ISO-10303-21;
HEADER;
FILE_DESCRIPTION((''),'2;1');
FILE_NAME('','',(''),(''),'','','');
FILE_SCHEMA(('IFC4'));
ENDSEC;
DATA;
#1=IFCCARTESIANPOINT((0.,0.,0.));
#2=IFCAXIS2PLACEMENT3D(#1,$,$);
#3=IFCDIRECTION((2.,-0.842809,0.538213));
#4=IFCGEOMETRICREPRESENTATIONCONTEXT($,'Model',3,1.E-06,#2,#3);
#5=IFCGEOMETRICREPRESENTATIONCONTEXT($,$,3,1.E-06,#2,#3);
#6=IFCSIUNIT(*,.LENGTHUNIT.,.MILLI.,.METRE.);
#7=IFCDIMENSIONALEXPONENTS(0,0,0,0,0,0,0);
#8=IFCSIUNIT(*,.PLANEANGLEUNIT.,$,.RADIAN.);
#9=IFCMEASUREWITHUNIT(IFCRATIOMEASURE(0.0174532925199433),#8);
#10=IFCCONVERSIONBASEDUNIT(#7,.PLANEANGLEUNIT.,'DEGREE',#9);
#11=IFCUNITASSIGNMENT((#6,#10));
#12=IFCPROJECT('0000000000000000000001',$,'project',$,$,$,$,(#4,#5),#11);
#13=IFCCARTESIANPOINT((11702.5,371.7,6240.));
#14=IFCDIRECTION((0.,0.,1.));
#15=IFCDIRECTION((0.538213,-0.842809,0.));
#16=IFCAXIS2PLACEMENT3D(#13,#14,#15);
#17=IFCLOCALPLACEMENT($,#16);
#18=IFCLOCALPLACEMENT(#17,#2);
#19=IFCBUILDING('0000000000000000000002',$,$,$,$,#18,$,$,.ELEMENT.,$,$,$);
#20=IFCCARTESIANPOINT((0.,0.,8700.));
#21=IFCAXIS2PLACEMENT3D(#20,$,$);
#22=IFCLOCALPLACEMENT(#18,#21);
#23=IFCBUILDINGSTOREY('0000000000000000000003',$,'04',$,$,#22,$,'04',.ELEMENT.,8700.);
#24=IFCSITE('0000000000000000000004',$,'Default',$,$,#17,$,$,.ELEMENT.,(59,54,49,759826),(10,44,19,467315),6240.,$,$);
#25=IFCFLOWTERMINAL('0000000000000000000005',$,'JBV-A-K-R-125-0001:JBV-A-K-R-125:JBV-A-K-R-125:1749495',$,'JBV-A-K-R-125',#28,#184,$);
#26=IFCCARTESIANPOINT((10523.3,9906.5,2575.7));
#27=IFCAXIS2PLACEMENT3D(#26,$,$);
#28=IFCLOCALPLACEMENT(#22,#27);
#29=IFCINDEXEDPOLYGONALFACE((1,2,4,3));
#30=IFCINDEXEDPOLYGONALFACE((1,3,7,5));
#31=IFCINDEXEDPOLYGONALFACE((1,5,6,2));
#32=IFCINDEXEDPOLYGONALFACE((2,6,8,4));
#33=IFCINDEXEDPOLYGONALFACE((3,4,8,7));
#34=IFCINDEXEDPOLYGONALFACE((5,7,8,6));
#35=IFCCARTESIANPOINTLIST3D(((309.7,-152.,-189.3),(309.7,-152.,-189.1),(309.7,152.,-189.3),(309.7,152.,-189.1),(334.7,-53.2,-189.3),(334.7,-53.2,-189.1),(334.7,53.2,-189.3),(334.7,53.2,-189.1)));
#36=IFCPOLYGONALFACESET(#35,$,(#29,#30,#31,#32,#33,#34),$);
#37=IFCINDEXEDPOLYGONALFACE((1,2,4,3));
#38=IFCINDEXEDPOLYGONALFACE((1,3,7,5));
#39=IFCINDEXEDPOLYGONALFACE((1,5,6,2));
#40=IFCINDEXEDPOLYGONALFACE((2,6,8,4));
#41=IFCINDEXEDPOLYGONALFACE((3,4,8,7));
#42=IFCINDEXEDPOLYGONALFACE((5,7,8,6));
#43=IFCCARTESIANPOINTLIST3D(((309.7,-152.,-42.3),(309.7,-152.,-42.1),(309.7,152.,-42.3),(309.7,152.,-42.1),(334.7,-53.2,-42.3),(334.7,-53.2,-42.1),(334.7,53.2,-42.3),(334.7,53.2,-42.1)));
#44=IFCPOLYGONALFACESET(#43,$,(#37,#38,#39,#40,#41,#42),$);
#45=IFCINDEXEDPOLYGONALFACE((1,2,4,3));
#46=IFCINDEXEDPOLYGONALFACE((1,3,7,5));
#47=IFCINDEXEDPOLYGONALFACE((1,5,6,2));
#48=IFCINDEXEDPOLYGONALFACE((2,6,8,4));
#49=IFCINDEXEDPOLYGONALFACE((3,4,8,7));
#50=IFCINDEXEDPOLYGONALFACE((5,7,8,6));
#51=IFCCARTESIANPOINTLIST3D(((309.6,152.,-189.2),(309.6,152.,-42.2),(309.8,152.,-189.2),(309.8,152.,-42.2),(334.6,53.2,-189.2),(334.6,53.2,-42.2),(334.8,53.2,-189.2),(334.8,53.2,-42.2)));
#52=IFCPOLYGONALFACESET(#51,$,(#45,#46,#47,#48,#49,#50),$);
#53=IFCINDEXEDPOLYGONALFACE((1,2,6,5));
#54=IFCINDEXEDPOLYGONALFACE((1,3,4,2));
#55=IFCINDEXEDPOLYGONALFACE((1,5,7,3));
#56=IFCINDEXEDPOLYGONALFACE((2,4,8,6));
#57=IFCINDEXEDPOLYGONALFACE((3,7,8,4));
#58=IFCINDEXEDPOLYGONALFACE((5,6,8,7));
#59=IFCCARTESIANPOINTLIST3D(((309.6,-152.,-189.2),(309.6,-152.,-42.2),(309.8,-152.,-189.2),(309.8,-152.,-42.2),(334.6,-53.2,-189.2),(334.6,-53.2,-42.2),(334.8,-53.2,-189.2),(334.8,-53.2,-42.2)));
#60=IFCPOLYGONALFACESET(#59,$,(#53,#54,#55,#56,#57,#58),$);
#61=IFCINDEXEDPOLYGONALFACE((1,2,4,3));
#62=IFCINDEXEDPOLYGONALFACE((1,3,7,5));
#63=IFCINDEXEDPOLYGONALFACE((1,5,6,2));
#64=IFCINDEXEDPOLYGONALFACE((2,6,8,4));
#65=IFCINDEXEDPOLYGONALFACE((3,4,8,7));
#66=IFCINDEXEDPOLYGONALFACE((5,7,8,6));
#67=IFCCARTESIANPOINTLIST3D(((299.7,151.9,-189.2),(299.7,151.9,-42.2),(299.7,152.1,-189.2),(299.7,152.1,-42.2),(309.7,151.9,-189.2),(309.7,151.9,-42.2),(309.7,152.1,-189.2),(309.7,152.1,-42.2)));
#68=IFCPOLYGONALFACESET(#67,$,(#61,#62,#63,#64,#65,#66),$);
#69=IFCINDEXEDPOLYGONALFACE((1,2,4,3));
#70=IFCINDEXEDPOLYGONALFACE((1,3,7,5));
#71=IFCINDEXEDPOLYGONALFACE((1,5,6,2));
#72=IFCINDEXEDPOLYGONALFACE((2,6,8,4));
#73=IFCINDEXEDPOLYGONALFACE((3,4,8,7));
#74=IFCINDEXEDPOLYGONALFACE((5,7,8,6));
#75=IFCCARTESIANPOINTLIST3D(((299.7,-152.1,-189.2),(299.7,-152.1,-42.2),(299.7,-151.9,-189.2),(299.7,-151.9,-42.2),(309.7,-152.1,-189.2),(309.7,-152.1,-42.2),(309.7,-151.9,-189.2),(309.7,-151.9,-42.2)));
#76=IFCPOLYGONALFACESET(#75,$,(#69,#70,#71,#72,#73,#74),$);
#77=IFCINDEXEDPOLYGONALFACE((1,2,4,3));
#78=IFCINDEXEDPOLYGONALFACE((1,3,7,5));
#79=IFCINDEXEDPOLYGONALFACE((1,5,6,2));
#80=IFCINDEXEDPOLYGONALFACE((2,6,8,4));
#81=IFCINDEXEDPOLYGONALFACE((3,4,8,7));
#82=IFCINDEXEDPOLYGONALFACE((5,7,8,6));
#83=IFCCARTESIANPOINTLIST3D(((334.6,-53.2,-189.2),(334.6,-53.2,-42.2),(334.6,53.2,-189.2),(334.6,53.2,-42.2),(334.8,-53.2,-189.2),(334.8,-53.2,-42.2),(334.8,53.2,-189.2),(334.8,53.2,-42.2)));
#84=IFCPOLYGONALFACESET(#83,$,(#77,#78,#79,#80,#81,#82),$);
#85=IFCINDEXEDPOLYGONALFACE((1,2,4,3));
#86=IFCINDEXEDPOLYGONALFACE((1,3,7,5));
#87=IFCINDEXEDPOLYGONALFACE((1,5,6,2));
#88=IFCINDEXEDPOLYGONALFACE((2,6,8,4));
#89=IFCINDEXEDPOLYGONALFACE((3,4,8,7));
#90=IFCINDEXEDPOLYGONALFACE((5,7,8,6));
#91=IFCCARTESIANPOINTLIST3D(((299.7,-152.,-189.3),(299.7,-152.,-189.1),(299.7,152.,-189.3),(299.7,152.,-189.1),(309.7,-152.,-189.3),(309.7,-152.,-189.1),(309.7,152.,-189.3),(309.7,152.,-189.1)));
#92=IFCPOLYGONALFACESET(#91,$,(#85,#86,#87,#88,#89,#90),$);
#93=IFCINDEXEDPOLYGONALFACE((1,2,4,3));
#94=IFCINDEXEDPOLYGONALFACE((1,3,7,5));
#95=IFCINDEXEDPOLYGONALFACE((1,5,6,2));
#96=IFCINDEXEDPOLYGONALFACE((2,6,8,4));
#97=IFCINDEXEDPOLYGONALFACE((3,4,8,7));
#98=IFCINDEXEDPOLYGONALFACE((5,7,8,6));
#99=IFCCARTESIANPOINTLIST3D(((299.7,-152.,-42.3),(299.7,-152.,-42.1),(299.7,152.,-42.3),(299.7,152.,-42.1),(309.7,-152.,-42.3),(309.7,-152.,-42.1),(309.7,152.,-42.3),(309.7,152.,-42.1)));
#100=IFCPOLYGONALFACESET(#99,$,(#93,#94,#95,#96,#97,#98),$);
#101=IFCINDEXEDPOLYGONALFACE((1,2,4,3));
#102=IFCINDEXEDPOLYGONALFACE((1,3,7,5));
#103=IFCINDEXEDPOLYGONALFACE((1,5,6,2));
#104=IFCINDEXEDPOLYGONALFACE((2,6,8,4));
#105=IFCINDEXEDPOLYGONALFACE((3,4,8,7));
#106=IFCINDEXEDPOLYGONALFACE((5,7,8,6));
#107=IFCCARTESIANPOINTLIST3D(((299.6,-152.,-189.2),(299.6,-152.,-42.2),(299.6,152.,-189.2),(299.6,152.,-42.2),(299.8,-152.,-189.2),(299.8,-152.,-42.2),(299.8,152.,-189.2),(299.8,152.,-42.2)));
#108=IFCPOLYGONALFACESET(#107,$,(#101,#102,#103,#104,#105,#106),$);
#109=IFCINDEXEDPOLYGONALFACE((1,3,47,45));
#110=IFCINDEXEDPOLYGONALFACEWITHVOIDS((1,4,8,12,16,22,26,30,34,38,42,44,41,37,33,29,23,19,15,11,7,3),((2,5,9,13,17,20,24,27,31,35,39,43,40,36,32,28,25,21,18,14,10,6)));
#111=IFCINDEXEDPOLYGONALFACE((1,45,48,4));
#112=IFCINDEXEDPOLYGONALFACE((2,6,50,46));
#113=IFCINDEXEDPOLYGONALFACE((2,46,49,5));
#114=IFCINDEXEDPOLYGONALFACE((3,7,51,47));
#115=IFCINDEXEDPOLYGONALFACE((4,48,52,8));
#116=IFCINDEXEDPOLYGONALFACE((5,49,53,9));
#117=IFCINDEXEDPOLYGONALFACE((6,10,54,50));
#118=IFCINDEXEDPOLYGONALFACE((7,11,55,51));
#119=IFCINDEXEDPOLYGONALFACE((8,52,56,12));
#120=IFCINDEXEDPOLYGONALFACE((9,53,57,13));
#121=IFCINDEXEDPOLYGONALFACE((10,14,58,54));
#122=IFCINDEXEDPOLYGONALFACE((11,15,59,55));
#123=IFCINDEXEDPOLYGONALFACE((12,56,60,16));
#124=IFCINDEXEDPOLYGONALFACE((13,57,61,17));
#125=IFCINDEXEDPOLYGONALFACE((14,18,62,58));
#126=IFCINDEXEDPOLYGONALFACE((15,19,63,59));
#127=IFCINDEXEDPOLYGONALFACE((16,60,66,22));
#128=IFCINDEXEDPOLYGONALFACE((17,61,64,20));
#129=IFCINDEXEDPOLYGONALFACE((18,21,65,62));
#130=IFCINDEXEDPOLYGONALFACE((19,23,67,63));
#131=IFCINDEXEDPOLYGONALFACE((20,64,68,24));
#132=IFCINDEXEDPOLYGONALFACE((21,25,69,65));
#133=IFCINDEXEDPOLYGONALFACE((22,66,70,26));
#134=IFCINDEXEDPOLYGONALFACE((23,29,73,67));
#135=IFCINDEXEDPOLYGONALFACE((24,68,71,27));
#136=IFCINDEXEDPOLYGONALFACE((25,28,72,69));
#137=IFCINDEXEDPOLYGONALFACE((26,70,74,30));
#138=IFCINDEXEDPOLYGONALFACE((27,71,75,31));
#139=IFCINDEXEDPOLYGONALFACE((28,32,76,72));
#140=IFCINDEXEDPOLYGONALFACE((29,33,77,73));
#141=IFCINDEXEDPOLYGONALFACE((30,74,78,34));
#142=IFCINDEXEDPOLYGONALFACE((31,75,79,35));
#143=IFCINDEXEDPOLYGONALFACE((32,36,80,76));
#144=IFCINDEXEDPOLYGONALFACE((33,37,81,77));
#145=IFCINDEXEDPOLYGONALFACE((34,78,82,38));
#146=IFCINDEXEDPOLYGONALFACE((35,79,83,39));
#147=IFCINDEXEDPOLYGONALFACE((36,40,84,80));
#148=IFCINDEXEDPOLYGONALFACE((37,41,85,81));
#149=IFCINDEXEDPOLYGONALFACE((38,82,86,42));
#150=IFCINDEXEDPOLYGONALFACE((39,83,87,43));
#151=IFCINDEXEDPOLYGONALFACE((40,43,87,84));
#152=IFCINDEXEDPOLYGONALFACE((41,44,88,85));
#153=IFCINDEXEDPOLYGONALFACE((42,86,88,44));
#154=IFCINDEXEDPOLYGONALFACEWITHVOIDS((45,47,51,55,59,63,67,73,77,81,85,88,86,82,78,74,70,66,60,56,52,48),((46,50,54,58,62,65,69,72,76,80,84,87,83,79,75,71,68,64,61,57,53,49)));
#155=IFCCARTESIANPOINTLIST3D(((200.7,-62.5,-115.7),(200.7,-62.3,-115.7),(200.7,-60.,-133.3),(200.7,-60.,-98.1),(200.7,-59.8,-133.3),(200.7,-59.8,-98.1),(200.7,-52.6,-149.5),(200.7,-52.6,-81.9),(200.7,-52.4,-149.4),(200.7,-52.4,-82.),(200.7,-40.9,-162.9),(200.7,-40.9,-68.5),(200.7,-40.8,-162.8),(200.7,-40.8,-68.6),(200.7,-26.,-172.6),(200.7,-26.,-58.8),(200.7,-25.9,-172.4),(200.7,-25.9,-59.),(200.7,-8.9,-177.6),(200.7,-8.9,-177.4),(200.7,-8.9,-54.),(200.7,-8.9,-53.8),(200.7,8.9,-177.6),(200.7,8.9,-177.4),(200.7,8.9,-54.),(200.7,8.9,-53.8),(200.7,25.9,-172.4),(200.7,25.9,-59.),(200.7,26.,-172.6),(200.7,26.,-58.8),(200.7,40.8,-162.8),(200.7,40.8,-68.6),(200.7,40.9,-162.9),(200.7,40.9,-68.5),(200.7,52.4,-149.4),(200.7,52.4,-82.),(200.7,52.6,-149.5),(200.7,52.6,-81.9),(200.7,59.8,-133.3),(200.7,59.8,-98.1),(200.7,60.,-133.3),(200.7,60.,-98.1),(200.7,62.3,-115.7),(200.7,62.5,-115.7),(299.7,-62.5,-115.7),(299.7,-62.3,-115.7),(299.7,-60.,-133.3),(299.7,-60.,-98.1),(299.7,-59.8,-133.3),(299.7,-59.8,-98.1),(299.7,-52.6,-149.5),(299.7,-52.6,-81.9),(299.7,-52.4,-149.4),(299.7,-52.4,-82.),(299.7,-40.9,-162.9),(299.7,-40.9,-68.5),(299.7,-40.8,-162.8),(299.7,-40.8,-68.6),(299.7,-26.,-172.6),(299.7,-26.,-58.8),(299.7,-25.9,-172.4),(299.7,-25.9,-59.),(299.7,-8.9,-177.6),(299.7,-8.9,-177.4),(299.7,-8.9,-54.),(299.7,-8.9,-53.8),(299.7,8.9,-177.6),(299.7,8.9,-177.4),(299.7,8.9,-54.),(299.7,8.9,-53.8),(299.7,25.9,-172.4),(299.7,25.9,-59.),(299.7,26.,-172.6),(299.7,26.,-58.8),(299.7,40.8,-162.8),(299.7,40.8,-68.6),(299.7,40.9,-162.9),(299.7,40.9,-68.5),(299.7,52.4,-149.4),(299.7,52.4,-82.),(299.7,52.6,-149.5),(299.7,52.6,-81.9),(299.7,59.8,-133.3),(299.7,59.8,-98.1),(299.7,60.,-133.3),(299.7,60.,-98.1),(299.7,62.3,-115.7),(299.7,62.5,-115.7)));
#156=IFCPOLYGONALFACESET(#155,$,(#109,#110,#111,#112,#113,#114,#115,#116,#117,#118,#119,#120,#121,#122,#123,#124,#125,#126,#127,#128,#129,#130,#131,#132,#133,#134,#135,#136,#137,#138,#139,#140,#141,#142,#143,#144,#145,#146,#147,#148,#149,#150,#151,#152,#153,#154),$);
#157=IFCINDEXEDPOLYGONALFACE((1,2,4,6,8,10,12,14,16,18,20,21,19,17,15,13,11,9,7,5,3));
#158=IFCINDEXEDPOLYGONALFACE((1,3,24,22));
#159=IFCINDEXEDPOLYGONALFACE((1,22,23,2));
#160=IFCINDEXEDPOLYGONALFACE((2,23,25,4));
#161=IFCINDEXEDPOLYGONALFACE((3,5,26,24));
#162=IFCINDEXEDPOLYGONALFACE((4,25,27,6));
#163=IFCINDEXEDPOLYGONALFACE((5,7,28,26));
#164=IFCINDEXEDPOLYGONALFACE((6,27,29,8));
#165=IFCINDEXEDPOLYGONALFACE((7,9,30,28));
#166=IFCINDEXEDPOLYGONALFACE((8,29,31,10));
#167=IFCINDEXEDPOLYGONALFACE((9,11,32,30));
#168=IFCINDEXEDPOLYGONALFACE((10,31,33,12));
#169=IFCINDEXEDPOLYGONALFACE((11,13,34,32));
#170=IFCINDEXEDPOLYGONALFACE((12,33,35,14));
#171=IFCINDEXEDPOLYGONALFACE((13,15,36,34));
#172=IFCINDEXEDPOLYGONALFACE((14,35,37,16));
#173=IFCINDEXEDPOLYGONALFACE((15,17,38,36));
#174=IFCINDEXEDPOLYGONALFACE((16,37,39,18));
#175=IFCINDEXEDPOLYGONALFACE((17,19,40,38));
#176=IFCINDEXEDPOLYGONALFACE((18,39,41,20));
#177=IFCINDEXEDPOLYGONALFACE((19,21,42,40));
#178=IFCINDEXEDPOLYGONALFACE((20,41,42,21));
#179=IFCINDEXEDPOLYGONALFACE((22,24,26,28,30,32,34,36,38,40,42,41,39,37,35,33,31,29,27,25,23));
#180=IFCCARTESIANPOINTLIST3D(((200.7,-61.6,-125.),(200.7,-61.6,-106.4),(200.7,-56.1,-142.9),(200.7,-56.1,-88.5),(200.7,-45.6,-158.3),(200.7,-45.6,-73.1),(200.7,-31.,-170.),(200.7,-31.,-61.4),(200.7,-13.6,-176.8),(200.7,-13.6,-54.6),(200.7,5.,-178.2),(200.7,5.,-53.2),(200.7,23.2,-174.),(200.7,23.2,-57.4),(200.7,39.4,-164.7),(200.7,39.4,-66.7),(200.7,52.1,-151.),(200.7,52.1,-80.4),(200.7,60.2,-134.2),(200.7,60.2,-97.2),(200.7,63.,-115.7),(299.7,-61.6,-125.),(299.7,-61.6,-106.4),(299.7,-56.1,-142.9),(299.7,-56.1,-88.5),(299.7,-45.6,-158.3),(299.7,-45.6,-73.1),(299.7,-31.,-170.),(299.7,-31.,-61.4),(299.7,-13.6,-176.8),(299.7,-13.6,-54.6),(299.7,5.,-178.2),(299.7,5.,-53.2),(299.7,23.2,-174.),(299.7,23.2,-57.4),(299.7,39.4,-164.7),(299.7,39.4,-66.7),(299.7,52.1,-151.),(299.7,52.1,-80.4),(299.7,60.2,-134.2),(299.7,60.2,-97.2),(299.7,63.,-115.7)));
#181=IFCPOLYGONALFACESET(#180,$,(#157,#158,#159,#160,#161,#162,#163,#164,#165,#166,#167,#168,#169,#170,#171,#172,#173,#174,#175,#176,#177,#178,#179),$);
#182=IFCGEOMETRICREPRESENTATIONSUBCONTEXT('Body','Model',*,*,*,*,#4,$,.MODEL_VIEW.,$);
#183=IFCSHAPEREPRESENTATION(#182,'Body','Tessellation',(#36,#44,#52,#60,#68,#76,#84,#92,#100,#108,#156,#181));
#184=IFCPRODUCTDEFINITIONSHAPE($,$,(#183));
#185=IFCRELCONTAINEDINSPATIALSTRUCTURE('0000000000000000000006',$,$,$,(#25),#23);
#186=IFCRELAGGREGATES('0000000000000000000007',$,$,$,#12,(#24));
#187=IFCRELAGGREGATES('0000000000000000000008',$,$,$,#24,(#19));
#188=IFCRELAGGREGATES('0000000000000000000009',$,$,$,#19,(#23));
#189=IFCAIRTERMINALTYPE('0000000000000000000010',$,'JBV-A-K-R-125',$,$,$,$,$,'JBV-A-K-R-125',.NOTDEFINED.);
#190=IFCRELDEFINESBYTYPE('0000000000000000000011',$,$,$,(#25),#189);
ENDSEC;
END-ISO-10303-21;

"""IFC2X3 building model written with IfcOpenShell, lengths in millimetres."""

from ifc_helpers import new_model, entity, si_unit, converted_unit, direction, frame, frame_2d, origin, origin_2d_with_axis, place, context, subcontext, project, spatial, polyline, circle_curve, parameter, trimmed, segment, composite_curve, rectangle, circle, outline, extrude, source, transform, mapped, type_object, type_shapes, element, save


model = new_model("IFC2X3")

# Units and contexts
model_context = context("Model", 3, precision=1e-06, world=origin(), true_north=direction((2.0, -0.842809, 0.538213)))
context_of_model = context(None, 3, precision=1e-06, world=origin(), true_north=direction((2.0, -0.842809, 0.538213)))
body_context = subcontext(model_context, "Body", "Model", "MODEL_VIEW")
ifc_project = project(units=[si_unit("LENGTHUNIT", "METRE", prefix="MILLI"), converted_unit("PLANEANGLEUNIT", "DEGREE", entity("IfcRatioMeasure", 0.0174532925199433), si_unit("PLANEANGLEUNIT", "RADIAN"), dimensions=[0, 0, 0, 0, 0, 0, 0])], contexts=[model_context, context_of_model])

# Site, building, storey
site_placement = place(None, frame((11702.5, 371.7, 6240.0), z_axis=(0.0, 0.0, 1.0), x_axis=(0.538213, -0.842809, 0.0)))
site = spatial("IfcSite", under=ifc_project, at=site_placement, Name="Default", CompositionType="ELEMENT", RefLatitude=(59, 54, 49, 759826), RefLongitude=(10, 44, 19, 467315), RefElevation=6240.0)
building_placement = place(site_placement, origin())
building = spatial("IfcBuilding", under=site, at=building_placement, CompositionType="ELEMENT")
storey_placement = place(building_placement, frame((0.0, 0.0, 8700.0)))
storey = spatial("IfcBuildingStorey", under=building, at=storey_placement, Name="04", LongName="04", CompositionType="ELEMENT", Elevation=8700.0)

# Flow terminal
air_terminal_type_1 = type_object("IfcAirTerminalType", Name="JBV-A-K-R-125", ElementType="JBV-A-K-R-125", PredefinedType="NOTDEFINED")
shared_shape_1 = source(origin(), body_context, "Body", "SweptSolid", [
    extrude(outline(polyline([(-152.0, -12.5), (152.0, -12.5), (53.2, 12.5), (-53.2, 12.5), (-152.0, -12.5)])), frame((322.2, 0.0, -189.3), z_axis=(0.0, 0.0, 1.0), x_axis=(0.0, -1.0, 0.0)), (0.0, 0.0, 1.0), 0.2),
    extrude(outline(polyline([(-152.0, -12.5), (152.0, -12.5), (53.2, 12.5), (-53.2, 12.5), (-152.0, -12.5)])), frame((322.2, 0.0, -42.3), z_axis=(0.0, 0.0, 1.0), x_axis=(0.0, -1.0, 0.0)), (0.0, 0.0, 1.0), 0.2),
    extrude(rectangle(XDim=0.2, YDim=101.9, at=frame_2d((0.0, 0.0), x_axis=(1.0, 0.0))), frame((322.2, 102.6, -189.2), z_axis=(0.0, 0.0, 1.0), x_axis=(0.969446, 0.245305, 0.0)), (0.0, 0.0, 1.0), 147.0),
    extrude(rectangle(XDim=0.2, YDim=101.9, at=frame_2d((0.0, 0.0), x_axis=(1.0, 0.0))), frame((322.2, -102.6, -189.2), z_axis=(0.0, 0.0, 1.0), x_axis=(-0.969446, 0.245305, 0.0)), (0.0, 0.0, 1.0), 147.0),
    extrude(rectangle(XDim=0.2, YDim=10.0, at=frame_2d((0.0, 0.0), x_axis=(1.0, 0.0))), frame((304.7, 152.0, -189.2), z_axis=(0.0, 0.0, 1.0), x_axis=(0.0, 1.0, 0.0)), (0.0, 0.0, 1.0), 147.0),
    extrude(rectangle(XDim=0.2, YDim=10.0, at=frame_2d((0.0, 0.0), x_axis=(1.0, 0.0))), frame((304.7, -152.0, -189.2), z_axis=(0.0, 0.0, 1.0), x_axis=(0.0, 1.0, 0.0)), (0.0, 0.0, 1.0), 147.0),
    extrude(rectangle(XDim=0.2, YDim=106.4, at=frame_2d((0.0, 0.0), x_axis=(1.0, 0.0))), frame((334.7, 0.0, -189.2)), (0.0, 0.0, 1.0), 147.0),
    extrude(rectangle(XDim=304.0, YDim=10.0, at=frame_2d((0.0, 0.0), x_axis=(1.0, 0.0))), frame((304.7, 0.0, -189.3), z_axis=(0.0, 0.0, 1.0), x_axis=(0.0, -1.0, 0.0)), (0.0, 0.0, 1.0), 0.2),
    extrude(rectangle(XDim=304.0, YDim=10.0, at=frame_2d((0.0, 0.0), x_axis=(1.0, 0.0))), frame((304.7, 0.0, -42.3), z_axis=(0.0, 0.0, 1.0), x_axis=(0.0, -1.0, 0.0)), (0.0, 0.0, 1.0), 0.2),
    extrude(rectangle(XDim=0.2, YDim=304.0, at=frame_2d((0.0, 0.0), x_axis=(1.0, 0.0))), frame((299.7, 0.0, -189.2)), (0.0, 0.0, 1.0), 147.0),
    extrude(outline(composite_curve([segment(trimmed(circle_curve(origin_2d_with_axis(), 62.5), [parameter(0.0)], [parameter(180.0)], True, "PARAMETER"), True, "CONTINUOUS"), segment(trimmed(circle_curve(origin_2d_with_axis(), 62.5), [parameter(180.0)], [parameter(360.0)], True, "PARAMETER"), True, "CONTINUOUS")], self_intersect=False), holes=[composite_curve([segment(trimmed(circle_curve(origin_2d_with_axis(), 62.3), [parameter(180.0)], [parameter(360.0)], True, "PARAMETER"), False, "CONTINUOUS"), segment(trimmed(circle_curve(origin_2d_with_axis(), 62.3), [parameter(0.0)], [parameter(180.0)], True, "PARAMETER"), False, "CONTINUOUS")], self_intersect=False)]), frame((200.7, 0.0, -115.7), z_axis=(1.0, 0.0, 0.0), x_axis=(0.0, 1.0, 0.0)), (0.0, 0.0, 1.0), 99.0),
    extrude(circle(Radius=62.6, at=frame_2d((0.0, 0.0), x_axis=(1.0, 0.0))), frame((200.7, 0.3, -115.7), z_axis=(1.0, 0.0, 0.0), x_axis=(0.0, 1.0, 0.0)), (0.0, 0.0, 1.0), 99.0),
])
type_shapes(air_terminal_type_1, [shared_shape_1])
for number, where, name in (
    (1, (10523.3, 9906.5, 2575.7), "JBV-A-K-R-125-0001:JBV-A-K-R-125:JBV-A-K-R-125:1749495"),
):
    element("IfcFlowTerminal", number, at=place(storey_placement, frame(where)), inside=storey, type_object=air_terminal_type_1, Name=name, ObjectType="JBV-A-K-R-125", context=body_context, shape_type="MappedRepresentation", body=[
        mapped(shared_shape_1, transform((0.0, 0.0, 0.0), scale=1.0)),
    ])

save(model, "model.ifc")
